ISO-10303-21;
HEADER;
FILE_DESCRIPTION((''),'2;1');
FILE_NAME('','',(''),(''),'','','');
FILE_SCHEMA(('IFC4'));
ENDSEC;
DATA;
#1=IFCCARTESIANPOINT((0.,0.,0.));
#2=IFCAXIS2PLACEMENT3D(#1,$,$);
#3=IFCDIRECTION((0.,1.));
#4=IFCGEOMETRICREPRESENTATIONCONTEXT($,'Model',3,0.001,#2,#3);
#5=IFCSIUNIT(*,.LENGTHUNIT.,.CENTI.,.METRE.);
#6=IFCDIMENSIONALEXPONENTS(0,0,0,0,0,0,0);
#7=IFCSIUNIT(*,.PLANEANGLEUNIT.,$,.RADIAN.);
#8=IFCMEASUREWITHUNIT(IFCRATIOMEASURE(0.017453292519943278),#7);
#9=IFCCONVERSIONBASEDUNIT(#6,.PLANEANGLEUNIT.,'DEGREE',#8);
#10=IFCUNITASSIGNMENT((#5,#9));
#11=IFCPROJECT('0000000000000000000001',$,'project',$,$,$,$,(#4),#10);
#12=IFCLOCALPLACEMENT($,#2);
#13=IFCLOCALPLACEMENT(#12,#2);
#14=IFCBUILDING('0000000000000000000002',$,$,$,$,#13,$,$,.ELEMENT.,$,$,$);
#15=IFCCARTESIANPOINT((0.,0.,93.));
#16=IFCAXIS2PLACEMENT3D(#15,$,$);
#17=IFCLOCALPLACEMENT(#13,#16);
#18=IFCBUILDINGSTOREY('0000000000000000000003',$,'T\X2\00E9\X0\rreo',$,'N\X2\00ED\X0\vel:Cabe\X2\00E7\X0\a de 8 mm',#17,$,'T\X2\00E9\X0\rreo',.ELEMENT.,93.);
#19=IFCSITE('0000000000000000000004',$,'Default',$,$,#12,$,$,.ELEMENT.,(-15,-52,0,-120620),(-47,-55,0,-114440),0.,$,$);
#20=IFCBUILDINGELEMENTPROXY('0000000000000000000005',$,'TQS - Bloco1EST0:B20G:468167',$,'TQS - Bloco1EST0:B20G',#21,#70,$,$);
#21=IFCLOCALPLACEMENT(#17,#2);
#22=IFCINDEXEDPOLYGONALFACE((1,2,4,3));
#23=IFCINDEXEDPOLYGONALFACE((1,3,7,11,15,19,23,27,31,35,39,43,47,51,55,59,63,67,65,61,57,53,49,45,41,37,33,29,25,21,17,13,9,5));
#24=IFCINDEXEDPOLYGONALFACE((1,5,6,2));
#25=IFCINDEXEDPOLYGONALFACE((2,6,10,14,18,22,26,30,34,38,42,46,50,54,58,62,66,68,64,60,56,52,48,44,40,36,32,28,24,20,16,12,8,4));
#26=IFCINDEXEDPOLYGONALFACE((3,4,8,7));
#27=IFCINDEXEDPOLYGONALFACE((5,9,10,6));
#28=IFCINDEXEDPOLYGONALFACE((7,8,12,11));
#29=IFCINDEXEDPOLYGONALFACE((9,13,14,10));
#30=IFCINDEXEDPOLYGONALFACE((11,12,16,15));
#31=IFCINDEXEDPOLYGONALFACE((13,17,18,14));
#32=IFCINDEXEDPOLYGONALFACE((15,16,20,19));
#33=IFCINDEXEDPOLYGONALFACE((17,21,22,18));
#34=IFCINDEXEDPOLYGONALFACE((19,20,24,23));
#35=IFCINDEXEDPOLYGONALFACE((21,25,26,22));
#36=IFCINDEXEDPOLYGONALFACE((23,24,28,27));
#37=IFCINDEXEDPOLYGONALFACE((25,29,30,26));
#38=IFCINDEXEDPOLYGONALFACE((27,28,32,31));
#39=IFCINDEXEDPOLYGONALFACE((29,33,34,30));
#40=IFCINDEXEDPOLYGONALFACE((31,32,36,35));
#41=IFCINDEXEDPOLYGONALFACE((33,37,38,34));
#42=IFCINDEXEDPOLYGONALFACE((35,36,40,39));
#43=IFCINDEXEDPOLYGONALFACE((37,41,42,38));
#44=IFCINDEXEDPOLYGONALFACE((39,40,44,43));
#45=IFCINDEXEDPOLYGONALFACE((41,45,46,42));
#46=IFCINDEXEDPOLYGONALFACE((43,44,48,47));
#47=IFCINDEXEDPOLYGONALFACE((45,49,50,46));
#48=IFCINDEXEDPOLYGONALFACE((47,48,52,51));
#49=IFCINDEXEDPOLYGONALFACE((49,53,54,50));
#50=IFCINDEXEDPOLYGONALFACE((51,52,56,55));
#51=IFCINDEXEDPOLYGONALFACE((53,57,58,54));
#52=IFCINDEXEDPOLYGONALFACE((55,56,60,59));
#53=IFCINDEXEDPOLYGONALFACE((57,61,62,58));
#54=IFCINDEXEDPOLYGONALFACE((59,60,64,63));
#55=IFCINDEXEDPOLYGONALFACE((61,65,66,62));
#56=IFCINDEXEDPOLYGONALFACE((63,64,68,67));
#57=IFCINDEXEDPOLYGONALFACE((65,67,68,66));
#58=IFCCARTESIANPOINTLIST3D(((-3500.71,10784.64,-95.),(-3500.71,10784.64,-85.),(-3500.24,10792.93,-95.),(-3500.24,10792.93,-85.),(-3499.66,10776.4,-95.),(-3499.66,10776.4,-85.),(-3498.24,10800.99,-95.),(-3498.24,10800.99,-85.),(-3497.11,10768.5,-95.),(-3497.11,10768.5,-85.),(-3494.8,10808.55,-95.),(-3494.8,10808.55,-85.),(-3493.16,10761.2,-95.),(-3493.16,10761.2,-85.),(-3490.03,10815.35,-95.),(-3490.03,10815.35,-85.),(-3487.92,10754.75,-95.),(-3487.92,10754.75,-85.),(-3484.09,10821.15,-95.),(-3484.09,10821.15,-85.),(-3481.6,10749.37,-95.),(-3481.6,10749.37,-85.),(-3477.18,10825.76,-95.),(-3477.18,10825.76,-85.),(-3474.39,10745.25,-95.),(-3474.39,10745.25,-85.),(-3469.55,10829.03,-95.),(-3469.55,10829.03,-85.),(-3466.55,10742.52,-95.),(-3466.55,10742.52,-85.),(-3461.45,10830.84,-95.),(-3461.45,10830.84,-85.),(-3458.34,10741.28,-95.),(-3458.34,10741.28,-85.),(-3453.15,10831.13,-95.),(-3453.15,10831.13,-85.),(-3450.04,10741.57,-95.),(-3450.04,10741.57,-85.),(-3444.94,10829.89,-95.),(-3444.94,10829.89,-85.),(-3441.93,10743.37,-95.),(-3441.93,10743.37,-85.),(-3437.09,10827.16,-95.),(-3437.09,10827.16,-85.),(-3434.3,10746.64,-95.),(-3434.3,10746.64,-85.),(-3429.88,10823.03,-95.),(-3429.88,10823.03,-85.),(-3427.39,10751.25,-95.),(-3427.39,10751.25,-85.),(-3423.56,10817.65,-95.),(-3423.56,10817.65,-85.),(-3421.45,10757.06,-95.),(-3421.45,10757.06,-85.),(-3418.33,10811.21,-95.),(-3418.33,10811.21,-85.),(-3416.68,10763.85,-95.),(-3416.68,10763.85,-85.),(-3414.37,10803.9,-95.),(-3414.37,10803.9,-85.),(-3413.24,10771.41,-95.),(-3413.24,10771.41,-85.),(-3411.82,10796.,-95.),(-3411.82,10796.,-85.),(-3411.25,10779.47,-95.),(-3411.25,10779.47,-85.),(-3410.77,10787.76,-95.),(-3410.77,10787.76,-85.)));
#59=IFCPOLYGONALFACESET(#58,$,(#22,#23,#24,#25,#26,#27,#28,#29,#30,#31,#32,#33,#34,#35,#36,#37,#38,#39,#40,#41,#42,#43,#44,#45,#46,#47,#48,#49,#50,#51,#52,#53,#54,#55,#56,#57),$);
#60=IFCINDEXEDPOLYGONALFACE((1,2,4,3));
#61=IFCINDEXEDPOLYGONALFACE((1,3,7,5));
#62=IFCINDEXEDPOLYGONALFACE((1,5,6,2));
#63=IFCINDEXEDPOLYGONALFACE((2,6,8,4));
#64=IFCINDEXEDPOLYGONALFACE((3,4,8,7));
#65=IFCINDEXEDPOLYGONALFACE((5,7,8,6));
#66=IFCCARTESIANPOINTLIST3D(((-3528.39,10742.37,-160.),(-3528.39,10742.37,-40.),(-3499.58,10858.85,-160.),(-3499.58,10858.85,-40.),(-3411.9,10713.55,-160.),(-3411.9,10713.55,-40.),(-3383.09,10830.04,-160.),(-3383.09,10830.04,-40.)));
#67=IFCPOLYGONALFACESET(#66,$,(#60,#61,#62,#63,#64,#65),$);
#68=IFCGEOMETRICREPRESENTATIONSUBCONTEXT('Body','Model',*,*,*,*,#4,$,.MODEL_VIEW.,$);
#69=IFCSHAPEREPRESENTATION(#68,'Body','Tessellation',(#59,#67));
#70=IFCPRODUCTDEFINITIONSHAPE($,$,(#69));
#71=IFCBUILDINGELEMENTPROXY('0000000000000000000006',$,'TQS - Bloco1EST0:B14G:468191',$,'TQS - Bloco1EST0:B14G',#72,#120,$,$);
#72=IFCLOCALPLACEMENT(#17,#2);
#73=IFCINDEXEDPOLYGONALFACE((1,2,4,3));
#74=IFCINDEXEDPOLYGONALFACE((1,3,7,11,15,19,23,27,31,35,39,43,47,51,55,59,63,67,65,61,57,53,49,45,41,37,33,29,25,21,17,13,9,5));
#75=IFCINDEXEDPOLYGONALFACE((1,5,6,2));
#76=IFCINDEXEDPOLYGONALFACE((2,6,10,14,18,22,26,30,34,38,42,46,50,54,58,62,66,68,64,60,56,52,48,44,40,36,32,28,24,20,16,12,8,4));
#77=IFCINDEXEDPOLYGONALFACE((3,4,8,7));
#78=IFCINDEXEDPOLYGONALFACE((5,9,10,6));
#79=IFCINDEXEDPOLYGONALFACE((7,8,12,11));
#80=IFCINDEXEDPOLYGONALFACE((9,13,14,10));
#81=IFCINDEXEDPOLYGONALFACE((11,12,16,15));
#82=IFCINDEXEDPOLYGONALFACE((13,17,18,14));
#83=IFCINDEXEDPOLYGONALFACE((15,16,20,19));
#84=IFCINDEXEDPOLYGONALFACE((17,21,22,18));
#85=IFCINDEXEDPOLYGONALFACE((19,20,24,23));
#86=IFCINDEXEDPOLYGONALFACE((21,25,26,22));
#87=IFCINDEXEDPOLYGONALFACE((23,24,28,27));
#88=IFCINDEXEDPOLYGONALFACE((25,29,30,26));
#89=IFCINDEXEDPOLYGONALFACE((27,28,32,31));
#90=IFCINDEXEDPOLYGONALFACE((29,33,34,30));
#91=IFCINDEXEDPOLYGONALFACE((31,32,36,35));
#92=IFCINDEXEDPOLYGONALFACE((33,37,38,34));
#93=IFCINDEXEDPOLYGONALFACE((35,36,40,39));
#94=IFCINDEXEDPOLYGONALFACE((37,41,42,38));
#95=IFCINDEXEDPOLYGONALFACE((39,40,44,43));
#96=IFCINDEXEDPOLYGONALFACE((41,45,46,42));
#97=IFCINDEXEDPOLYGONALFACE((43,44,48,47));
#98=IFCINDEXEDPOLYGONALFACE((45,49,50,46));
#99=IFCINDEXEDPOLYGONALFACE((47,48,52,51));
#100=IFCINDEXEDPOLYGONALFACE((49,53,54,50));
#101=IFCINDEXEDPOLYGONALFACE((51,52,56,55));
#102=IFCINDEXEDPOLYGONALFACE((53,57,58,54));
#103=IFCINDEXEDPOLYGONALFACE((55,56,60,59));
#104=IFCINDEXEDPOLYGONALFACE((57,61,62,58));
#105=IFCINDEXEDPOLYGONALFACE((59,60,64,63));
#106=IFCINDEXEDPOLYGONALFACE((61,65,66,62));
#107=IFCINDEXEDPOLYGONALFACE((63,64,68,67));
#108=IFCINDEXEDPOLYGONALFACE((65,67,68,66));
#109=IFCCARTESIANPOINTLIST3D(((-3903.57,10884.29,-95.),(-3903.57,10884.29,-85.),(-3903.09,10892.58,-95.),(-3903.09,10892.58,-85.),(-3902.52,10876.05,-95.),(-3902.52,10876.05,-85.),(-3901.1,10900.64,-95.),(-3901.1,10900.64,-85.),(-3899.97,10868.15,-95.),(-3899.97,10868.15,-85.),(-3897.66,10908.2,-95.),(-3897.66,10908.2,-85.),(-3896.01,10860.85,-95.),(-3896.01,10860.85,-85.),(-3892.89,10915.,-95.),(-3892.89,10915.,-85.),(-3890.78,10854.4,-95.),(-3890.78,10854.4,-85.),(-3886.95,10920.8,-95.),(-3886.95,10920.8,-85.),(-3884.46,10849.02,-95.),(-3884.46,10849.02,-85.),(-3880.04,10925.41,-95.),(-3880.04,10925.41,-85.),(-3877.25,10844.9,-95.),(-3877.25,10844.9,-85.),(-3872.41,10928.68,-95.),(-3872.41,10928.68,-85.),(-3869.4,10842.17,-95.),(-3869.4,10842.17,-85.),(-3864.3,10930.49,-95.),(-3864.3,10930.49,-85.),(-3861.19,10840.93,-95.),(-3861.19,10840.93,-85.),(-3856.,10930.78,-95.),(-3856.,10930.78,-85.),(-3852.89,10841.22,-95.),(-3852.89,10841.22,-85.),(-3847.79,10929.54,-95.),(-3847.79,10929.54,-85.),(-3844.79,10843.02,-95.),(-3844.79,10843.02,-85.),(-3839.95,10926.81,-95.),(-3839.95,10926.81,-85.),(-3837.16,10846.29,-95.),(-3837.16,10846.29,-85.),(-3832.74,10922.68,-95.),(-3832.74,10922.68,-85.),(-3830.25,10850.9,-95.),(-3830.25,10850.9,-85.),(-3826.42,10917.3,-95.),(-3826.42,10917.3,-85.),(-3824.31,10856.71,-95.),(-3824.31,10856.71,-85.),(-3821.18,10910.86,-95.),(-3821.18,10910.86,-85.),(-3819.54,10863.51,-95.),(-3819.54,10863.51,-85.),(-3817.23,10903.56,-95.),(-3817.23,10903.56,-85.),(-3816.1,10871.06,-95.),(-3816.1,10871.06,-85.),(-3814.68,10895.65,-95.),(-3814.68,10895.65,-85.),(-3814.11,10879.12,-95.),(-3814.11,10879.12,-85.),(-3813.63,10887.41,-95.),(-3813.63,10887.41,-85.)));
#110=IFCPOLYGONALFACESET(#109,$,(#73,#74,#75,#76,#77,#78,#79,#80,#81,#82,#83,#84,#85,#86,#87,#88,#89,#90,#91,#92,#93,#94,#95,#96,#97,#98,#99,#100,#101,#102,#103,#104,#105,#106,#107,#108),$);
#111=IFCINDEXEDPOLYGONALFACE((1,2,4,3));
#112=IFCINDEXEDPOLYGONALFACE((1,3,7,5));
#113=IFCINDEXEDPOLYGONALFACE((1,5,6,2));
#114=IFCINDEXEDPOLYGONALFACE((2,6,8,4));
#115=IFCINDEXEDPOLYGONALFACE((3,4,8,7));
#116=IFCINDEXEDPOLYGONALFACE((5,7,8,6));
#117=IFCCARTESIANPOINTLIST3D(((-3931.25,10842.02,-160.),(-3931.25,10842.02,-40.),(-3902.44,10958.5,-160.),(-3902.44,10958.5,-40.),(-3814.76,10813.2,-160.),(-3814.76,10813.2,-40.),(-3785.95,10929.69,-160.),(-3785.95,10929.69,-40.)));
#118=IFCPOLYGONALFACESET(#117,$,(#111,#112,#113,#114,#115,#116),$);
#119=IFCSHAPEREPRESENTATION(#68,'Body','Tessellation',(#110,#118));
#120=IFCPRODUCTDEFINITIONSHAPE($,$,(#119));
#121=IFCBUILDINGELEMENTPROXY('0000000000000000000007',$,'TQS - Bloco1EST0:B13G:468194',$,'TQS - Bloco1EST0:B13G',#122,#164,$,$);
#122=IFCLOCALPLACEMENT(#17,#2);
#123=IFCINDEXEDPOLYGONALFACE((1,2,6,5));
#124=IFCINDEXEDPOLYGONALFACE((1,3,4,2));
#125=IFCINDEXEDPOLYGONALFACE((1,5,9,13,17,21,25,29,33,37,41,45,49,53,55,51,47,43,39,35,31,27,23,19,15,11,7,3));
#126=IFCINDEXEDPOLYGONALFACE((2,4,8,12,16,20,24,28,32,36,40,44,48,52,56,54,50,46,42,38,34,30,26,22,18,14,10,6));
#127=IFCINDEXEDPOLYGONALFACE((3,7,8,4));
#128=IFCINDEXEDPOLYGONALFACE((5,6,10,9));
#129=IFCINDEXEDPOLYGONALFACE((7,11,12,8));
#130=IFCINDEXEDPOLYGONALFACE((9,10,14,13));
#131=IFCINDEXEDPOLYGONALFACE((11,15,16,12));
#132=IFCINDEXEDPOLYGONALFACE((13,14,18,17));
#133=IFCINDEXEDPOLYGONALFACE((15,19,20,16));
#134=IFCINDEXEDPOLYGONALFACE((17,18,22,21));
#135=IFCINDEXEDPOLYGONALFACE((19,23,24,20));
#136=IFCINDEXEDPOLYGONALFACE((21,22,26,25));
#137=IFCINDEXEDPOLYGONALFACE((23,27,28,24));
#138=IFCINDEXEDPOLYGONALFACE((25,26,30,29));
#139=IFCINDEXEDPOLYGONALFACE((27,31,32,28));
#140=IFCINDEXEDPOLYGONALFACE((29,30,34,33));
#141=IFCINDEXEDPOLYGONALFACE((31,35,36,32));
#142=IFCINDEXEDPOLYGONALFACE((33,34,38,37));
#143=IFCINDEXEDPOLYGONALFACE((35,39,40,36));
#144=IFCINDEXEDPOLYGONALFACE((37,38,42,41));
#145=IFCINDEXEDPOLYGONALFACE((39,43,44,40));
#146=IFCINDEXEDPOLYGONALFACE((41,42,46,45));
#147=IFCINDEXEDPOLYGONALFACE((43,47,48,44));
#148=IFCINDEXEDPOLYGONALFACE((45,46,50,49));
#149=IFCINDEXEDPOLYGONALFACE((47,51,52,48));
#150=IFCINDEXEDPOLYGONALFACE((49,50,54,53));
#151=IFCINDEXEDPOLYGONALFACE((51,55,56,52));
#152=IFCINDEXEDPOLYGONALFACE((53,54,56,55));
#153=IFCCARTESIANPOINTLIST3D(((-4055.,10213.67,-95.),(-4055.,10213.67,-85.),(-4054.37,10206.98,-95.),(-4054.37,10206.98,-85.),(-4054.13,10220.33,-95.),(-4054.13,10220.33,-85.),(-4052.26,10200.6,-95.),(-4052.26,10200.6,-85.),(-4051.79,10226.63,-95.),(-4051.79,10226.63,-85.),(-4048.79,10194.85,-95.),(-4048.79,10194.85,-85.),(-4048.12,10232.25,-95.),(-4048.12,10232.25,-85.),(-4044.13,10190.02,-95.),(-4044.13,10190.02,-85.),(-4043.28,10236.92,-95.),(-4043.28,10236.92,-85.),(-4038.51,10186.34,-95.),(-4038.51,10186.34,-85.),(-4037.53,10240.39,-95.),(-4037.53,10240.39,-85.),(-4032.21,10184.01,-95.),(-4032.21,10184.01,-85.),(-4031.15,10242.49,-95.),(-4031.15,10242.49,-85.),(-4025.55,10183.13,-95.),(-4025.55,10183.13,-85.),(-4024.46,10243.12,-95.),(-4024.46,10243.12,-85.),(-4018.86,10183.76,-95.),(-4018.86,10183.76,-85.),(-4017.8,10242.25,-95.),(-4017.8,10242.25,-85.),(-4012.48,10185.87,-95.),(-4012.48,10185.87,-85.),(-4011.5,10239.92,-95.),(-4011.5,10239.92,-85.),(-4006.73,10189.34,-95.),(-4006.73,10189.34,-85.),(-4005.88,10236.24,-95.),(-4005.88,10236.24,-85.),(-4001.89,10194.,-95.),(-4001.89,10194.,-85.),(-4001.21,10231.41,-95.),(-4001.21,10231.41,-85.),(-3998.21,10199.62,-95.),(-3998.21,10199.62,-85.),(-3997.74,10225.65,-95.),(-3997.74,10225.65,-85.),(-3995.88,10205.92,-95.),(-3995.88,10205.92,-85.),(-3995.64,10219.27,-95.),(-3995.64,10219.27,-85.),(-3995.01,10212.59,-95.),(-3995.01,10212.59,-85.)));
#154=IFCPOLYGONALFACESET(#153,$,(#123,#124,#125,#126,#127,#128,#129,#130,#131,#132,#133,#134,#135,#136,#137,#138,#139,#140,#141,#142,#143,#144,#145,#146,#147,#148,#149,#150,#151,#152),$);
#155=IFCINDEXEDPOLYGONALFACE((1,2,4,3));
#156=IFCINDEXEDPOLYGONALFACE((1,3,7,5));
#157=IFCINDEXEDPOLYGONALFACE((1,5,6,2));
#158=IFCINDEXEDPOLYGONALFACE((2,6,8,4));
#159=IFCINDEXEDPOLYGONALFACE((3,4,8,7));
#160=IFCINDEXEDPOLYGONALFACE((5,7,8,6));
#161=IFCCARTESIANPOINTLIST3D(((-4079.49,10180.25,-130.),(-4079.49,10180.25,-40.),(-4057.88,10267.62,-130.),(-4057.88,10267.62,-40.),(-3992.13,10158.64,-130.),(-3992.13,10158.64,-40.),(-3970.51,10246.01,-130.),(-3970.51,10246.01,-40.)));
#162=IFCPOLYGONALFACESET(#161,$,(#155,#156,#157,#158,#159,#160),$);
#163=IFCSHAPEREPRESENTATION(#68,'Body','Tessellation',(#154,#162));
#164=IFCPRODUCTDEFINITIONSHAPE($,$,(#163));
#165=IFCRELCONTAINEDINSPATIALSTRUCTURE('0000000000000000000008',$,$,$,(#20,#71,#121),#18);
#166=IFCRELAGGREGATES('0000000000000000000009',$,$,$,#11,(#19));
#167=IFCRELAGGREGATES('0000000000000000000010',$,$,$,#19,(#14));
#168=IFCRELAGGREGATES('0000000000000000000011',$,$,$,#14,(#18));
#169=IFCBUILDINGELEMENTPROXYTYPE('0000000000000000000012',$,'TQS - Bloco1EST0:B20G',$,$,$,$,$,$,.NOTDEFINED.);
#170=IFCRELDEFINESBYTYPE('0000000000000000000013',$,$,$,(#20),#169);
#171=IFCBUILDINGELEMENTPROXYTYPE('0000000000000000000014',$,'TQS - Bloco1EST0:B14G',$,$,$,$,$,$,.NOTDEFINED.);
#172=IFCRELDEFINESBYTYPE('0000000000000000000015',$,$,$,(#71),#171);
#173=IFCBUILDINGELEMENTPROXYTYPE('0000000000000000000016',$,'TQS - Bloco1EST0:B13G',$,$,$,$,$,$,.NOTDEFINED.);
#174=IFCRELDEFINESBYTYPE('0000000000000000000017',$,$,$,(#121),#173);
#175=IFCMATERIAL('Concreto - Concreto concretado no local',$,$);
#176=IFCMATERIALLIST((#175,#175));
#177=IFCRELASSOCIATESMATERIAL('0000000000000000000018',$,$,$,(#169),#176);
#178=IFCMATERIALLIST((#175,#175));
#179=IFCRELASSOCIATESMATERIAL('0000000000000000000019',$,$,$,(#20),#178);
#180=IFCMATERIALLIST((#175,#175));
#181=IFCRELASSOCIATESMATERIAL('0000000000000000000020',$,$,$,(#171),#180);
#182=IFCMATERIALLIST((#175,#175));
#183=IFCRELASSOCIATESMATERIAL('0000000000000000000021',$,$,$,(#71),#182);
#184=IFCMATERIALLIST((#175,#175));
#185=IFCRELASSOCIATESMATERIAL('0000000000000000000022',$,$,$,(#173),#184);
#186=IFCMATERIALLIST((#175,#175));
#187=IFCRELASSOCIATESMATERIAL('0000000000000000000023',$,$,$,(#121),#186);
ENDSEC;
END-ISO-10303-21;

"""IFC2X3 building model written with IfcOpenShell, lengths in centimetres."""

from ifc_helpers import new_model, entity, si_unit, converted_unit, direction, frame, frame_2d, origin, origin_2d_with_axis, place, context, subcontext, project, spatial, rectangle, circle, extrude, source, transform, mapped, material, material_list, type_object, type_shapes, element, save


model = new_model("IFC2X3")

# Units and contexts
model_context = context("Model", 3, precision=0.001, world=origin(), true_north=direction((0.0, 1.0)))
body_context = subcontext(model_context, "Body", "Model", "MODEL_VIEW")
ifc_project = project(units=[si_unit("LENGTHUNIT", "METRE", prefix="CENTI"), converted_unit("PLANEANGLEUNIT", "DEGREE", entity("IfcRatioMeasure", 0.017453292519943278), si_unit("PLANEANGLEUNIT", "RADIAN"), dimensions=[0, 0, 0, 0, 0, 0, 0])], contexts=[model_context])

# Site, building, storey
site_placement = place(None, origin())
site = spatial("IfcSite", under=ifc_project, at=site_placement, Name="Default", CompositionType="ELEMENT", RefLatitude=(-15, -52, 0, -120620), RefLongitude=(-47, -55, 0, -114440), RefElevation=0.0)
building_placement = place(site_placement, origin())
building = spatial("IfcBuilding", under=site, at=building_placement, CompositionType="ELEMENT")
storey_placement = place(building_placement, frame((0.0, 0.0, 93.0)))
storey = spatial("IfcBuildingStorey", under=building, at=storey_placement, Name="Térreo", ObjectType="Nível:Cabeça de 8 mm", LongName="Térreo", CompositionType="ELEMENT", Elevation=93.0)

# Building element proxies
ifc_material_1 = material(Name="Concreto - Concreto concretado no local")
ifc_material_list_1 = material_list([ifc_material_1, ifc_material_1])
ifc_material_list_2 = material_list([ifc_material_1, ifc_material_1])
building_element_proxy_type_1 = type_object("IfcBuildingElementProxyType", Name="TQS - Bloco1EST0:B20G", PredefinedType="NOTDEFINED", material=ifc_material_list_2)
shared_shape_1 = source(origin(), body_context, "Body", "SweptSolid", [
    extrude(circle(Radius=45.0, at=frame_2d((0.0, 0.0), x_axis=(1.0, 0.0))), frame((0.0, 0.0, -55.0)), (0.0, 0.0, 1.0), 10.0),
    extrude(rectangle(XDim=120.0, YDim=120.0, at=origin_2d_with_axis()), frame((0.0, 0.0, -120.0), z_axis=(0.0, 0.0, 1.0), x_axis=(-1.0, 0.0, 0.0)), (0.0, 0.0, 1.0), 120.0),
])
type_shapes(building_element_proxy_type_1, [shared_shape_1])
proxy_1_placement = place(storey_placement, frame((-3455.74, 10786.2, -40.0), z_axis=(0.0, 0.0, 1.0), x_axis=(0.240122, 0.970743, 0.0)))
element("IfcBuildingElementProxy", 1, at=proxy_1_placement, inside=storey, type_object=building_element_proxy_type_1, material=ifc_material_list_1, Name="TQS - Bloco1EST0:B20G:468167", ObjectType="TQS - Bloco1EST0:B20G", context=body_context, shape_type="MappedRepresentation", body=[
    mapped(shared_shape_1, transform((0.0, 0.0, 0.0), scale=1.0)),
])
ifc_material_list_3 = material_list([ifc_material_1, ifc_material_1])
ifc_material_list_4 = material_list([ifc_material_1, ifc_material_1])
building_element_proxy_type_2 = type_object("IfcBuildingElementProxyType", Name="TQS - Bloco1EST0:B14G", PredefinedType="NOTDEFINED", material=ifc_material_list_4)
shared_shape_2 = source(origin(), body_context, "Body", "SweptSolid", [
    extrude(circle(Radius=45.0, at=frame_2d((0.0, 0.0), x_axis=(1.0, 0.0))), frame((0.0, 0.0, -55.0)), (0.0, 0.0, 1.0), 10.0),
    extrude(rectangle(XDim=120.0, YDim=120.0, at=origin_2d_with_axis()), frame((0.0, 0.0, -120.0), z_axis=(0.0, 0.0, 1.0), x_axis=(-1.0, 0.0, 0.0)), (0.0, 0.0, 1.0), 120.0),
])
type_shapes(building_element_proxy_type_2, [shared_shape_2])
proxy_2_placement = place(storey_placement, frame((-3858.6, 10885.85, -40.0), z_axis=(0.0, 0.0, 1.0), x_axis=(0.240122, 0.970743, 0.0)))
element("IfcBuildingElementProxy", 2, at=proxy_2_placement, inside=storey, type_object=building_element_proxy_type_2, material=ifc_material_list_3, Name="TQS - Bloco1EST0:B14G:468191", ObjectType="TQS - Bloco1EST0:B14G", context=body_context, shape_type="MappedRepresentation", body=[
    mapped(shared_shape_2, transform((0.0, 0.0, 0.0), scale=1.0)),
])
ifc_material_list_5 = material_list([ifc_material_1, ifc_material_1])
ifc_material_list_6 = material_list([ifc_material_1, ifc_material_1])
building_element_proxy_type_3 = type_object("IfcBuildingElementProxyType", Name="TQS - Bloco1EST0:B13G", PredefinedType="NOTDEFINED", material=ifc_material_list_6)
shared_shape_3 = source(origin(), body_context, "Body", "SweptSolid", [
    extrude(circle(Radius=30.0, at=frame_2d((0.0, 0.0), x_axis=(1.0, 0.0))), frame((0.0, 0.0, -55.0)), (0.0, 0.0, 1.0), 10.0),
    extrude(rectangle(XDim=90.0, YDim=90.0, at=origin_2d_with_axis()), frame((0.0, 0.0, -90.0), z_axis=(0.0, 0.0, 1.0), x_axis=(-1.0, 0.0, 0.0)), (0.0, 0.0, 1.0), 90.0),
])
type_shapes(building_element_proxy_type_3, [shared_shape_3])
proxy_3_placement = place(storey_placement, frame((-4025.0, 10213.13, -40.0), z_axis=(0.0, 0.0, 1.0), x_axis=(0.240122, 0.970743, 0.0)))
element("IfcBuildingElementProxy", 3, at=proxy_3_placement, inside=storey, type_object=building_element_proxy_type_3, material=ifc_material_list_5, Name="TQS - Bloco1EST0:B13G:468194", ObjectType="TQS - Bloco1EST0:B13G", context=body_context, shape_type="MappedRepresentation", body=[
    mapped(shared_shape_3, transform((0.0, 0.0, 0.0), scale=1.0)),
])

save(model, "model.ifc")
